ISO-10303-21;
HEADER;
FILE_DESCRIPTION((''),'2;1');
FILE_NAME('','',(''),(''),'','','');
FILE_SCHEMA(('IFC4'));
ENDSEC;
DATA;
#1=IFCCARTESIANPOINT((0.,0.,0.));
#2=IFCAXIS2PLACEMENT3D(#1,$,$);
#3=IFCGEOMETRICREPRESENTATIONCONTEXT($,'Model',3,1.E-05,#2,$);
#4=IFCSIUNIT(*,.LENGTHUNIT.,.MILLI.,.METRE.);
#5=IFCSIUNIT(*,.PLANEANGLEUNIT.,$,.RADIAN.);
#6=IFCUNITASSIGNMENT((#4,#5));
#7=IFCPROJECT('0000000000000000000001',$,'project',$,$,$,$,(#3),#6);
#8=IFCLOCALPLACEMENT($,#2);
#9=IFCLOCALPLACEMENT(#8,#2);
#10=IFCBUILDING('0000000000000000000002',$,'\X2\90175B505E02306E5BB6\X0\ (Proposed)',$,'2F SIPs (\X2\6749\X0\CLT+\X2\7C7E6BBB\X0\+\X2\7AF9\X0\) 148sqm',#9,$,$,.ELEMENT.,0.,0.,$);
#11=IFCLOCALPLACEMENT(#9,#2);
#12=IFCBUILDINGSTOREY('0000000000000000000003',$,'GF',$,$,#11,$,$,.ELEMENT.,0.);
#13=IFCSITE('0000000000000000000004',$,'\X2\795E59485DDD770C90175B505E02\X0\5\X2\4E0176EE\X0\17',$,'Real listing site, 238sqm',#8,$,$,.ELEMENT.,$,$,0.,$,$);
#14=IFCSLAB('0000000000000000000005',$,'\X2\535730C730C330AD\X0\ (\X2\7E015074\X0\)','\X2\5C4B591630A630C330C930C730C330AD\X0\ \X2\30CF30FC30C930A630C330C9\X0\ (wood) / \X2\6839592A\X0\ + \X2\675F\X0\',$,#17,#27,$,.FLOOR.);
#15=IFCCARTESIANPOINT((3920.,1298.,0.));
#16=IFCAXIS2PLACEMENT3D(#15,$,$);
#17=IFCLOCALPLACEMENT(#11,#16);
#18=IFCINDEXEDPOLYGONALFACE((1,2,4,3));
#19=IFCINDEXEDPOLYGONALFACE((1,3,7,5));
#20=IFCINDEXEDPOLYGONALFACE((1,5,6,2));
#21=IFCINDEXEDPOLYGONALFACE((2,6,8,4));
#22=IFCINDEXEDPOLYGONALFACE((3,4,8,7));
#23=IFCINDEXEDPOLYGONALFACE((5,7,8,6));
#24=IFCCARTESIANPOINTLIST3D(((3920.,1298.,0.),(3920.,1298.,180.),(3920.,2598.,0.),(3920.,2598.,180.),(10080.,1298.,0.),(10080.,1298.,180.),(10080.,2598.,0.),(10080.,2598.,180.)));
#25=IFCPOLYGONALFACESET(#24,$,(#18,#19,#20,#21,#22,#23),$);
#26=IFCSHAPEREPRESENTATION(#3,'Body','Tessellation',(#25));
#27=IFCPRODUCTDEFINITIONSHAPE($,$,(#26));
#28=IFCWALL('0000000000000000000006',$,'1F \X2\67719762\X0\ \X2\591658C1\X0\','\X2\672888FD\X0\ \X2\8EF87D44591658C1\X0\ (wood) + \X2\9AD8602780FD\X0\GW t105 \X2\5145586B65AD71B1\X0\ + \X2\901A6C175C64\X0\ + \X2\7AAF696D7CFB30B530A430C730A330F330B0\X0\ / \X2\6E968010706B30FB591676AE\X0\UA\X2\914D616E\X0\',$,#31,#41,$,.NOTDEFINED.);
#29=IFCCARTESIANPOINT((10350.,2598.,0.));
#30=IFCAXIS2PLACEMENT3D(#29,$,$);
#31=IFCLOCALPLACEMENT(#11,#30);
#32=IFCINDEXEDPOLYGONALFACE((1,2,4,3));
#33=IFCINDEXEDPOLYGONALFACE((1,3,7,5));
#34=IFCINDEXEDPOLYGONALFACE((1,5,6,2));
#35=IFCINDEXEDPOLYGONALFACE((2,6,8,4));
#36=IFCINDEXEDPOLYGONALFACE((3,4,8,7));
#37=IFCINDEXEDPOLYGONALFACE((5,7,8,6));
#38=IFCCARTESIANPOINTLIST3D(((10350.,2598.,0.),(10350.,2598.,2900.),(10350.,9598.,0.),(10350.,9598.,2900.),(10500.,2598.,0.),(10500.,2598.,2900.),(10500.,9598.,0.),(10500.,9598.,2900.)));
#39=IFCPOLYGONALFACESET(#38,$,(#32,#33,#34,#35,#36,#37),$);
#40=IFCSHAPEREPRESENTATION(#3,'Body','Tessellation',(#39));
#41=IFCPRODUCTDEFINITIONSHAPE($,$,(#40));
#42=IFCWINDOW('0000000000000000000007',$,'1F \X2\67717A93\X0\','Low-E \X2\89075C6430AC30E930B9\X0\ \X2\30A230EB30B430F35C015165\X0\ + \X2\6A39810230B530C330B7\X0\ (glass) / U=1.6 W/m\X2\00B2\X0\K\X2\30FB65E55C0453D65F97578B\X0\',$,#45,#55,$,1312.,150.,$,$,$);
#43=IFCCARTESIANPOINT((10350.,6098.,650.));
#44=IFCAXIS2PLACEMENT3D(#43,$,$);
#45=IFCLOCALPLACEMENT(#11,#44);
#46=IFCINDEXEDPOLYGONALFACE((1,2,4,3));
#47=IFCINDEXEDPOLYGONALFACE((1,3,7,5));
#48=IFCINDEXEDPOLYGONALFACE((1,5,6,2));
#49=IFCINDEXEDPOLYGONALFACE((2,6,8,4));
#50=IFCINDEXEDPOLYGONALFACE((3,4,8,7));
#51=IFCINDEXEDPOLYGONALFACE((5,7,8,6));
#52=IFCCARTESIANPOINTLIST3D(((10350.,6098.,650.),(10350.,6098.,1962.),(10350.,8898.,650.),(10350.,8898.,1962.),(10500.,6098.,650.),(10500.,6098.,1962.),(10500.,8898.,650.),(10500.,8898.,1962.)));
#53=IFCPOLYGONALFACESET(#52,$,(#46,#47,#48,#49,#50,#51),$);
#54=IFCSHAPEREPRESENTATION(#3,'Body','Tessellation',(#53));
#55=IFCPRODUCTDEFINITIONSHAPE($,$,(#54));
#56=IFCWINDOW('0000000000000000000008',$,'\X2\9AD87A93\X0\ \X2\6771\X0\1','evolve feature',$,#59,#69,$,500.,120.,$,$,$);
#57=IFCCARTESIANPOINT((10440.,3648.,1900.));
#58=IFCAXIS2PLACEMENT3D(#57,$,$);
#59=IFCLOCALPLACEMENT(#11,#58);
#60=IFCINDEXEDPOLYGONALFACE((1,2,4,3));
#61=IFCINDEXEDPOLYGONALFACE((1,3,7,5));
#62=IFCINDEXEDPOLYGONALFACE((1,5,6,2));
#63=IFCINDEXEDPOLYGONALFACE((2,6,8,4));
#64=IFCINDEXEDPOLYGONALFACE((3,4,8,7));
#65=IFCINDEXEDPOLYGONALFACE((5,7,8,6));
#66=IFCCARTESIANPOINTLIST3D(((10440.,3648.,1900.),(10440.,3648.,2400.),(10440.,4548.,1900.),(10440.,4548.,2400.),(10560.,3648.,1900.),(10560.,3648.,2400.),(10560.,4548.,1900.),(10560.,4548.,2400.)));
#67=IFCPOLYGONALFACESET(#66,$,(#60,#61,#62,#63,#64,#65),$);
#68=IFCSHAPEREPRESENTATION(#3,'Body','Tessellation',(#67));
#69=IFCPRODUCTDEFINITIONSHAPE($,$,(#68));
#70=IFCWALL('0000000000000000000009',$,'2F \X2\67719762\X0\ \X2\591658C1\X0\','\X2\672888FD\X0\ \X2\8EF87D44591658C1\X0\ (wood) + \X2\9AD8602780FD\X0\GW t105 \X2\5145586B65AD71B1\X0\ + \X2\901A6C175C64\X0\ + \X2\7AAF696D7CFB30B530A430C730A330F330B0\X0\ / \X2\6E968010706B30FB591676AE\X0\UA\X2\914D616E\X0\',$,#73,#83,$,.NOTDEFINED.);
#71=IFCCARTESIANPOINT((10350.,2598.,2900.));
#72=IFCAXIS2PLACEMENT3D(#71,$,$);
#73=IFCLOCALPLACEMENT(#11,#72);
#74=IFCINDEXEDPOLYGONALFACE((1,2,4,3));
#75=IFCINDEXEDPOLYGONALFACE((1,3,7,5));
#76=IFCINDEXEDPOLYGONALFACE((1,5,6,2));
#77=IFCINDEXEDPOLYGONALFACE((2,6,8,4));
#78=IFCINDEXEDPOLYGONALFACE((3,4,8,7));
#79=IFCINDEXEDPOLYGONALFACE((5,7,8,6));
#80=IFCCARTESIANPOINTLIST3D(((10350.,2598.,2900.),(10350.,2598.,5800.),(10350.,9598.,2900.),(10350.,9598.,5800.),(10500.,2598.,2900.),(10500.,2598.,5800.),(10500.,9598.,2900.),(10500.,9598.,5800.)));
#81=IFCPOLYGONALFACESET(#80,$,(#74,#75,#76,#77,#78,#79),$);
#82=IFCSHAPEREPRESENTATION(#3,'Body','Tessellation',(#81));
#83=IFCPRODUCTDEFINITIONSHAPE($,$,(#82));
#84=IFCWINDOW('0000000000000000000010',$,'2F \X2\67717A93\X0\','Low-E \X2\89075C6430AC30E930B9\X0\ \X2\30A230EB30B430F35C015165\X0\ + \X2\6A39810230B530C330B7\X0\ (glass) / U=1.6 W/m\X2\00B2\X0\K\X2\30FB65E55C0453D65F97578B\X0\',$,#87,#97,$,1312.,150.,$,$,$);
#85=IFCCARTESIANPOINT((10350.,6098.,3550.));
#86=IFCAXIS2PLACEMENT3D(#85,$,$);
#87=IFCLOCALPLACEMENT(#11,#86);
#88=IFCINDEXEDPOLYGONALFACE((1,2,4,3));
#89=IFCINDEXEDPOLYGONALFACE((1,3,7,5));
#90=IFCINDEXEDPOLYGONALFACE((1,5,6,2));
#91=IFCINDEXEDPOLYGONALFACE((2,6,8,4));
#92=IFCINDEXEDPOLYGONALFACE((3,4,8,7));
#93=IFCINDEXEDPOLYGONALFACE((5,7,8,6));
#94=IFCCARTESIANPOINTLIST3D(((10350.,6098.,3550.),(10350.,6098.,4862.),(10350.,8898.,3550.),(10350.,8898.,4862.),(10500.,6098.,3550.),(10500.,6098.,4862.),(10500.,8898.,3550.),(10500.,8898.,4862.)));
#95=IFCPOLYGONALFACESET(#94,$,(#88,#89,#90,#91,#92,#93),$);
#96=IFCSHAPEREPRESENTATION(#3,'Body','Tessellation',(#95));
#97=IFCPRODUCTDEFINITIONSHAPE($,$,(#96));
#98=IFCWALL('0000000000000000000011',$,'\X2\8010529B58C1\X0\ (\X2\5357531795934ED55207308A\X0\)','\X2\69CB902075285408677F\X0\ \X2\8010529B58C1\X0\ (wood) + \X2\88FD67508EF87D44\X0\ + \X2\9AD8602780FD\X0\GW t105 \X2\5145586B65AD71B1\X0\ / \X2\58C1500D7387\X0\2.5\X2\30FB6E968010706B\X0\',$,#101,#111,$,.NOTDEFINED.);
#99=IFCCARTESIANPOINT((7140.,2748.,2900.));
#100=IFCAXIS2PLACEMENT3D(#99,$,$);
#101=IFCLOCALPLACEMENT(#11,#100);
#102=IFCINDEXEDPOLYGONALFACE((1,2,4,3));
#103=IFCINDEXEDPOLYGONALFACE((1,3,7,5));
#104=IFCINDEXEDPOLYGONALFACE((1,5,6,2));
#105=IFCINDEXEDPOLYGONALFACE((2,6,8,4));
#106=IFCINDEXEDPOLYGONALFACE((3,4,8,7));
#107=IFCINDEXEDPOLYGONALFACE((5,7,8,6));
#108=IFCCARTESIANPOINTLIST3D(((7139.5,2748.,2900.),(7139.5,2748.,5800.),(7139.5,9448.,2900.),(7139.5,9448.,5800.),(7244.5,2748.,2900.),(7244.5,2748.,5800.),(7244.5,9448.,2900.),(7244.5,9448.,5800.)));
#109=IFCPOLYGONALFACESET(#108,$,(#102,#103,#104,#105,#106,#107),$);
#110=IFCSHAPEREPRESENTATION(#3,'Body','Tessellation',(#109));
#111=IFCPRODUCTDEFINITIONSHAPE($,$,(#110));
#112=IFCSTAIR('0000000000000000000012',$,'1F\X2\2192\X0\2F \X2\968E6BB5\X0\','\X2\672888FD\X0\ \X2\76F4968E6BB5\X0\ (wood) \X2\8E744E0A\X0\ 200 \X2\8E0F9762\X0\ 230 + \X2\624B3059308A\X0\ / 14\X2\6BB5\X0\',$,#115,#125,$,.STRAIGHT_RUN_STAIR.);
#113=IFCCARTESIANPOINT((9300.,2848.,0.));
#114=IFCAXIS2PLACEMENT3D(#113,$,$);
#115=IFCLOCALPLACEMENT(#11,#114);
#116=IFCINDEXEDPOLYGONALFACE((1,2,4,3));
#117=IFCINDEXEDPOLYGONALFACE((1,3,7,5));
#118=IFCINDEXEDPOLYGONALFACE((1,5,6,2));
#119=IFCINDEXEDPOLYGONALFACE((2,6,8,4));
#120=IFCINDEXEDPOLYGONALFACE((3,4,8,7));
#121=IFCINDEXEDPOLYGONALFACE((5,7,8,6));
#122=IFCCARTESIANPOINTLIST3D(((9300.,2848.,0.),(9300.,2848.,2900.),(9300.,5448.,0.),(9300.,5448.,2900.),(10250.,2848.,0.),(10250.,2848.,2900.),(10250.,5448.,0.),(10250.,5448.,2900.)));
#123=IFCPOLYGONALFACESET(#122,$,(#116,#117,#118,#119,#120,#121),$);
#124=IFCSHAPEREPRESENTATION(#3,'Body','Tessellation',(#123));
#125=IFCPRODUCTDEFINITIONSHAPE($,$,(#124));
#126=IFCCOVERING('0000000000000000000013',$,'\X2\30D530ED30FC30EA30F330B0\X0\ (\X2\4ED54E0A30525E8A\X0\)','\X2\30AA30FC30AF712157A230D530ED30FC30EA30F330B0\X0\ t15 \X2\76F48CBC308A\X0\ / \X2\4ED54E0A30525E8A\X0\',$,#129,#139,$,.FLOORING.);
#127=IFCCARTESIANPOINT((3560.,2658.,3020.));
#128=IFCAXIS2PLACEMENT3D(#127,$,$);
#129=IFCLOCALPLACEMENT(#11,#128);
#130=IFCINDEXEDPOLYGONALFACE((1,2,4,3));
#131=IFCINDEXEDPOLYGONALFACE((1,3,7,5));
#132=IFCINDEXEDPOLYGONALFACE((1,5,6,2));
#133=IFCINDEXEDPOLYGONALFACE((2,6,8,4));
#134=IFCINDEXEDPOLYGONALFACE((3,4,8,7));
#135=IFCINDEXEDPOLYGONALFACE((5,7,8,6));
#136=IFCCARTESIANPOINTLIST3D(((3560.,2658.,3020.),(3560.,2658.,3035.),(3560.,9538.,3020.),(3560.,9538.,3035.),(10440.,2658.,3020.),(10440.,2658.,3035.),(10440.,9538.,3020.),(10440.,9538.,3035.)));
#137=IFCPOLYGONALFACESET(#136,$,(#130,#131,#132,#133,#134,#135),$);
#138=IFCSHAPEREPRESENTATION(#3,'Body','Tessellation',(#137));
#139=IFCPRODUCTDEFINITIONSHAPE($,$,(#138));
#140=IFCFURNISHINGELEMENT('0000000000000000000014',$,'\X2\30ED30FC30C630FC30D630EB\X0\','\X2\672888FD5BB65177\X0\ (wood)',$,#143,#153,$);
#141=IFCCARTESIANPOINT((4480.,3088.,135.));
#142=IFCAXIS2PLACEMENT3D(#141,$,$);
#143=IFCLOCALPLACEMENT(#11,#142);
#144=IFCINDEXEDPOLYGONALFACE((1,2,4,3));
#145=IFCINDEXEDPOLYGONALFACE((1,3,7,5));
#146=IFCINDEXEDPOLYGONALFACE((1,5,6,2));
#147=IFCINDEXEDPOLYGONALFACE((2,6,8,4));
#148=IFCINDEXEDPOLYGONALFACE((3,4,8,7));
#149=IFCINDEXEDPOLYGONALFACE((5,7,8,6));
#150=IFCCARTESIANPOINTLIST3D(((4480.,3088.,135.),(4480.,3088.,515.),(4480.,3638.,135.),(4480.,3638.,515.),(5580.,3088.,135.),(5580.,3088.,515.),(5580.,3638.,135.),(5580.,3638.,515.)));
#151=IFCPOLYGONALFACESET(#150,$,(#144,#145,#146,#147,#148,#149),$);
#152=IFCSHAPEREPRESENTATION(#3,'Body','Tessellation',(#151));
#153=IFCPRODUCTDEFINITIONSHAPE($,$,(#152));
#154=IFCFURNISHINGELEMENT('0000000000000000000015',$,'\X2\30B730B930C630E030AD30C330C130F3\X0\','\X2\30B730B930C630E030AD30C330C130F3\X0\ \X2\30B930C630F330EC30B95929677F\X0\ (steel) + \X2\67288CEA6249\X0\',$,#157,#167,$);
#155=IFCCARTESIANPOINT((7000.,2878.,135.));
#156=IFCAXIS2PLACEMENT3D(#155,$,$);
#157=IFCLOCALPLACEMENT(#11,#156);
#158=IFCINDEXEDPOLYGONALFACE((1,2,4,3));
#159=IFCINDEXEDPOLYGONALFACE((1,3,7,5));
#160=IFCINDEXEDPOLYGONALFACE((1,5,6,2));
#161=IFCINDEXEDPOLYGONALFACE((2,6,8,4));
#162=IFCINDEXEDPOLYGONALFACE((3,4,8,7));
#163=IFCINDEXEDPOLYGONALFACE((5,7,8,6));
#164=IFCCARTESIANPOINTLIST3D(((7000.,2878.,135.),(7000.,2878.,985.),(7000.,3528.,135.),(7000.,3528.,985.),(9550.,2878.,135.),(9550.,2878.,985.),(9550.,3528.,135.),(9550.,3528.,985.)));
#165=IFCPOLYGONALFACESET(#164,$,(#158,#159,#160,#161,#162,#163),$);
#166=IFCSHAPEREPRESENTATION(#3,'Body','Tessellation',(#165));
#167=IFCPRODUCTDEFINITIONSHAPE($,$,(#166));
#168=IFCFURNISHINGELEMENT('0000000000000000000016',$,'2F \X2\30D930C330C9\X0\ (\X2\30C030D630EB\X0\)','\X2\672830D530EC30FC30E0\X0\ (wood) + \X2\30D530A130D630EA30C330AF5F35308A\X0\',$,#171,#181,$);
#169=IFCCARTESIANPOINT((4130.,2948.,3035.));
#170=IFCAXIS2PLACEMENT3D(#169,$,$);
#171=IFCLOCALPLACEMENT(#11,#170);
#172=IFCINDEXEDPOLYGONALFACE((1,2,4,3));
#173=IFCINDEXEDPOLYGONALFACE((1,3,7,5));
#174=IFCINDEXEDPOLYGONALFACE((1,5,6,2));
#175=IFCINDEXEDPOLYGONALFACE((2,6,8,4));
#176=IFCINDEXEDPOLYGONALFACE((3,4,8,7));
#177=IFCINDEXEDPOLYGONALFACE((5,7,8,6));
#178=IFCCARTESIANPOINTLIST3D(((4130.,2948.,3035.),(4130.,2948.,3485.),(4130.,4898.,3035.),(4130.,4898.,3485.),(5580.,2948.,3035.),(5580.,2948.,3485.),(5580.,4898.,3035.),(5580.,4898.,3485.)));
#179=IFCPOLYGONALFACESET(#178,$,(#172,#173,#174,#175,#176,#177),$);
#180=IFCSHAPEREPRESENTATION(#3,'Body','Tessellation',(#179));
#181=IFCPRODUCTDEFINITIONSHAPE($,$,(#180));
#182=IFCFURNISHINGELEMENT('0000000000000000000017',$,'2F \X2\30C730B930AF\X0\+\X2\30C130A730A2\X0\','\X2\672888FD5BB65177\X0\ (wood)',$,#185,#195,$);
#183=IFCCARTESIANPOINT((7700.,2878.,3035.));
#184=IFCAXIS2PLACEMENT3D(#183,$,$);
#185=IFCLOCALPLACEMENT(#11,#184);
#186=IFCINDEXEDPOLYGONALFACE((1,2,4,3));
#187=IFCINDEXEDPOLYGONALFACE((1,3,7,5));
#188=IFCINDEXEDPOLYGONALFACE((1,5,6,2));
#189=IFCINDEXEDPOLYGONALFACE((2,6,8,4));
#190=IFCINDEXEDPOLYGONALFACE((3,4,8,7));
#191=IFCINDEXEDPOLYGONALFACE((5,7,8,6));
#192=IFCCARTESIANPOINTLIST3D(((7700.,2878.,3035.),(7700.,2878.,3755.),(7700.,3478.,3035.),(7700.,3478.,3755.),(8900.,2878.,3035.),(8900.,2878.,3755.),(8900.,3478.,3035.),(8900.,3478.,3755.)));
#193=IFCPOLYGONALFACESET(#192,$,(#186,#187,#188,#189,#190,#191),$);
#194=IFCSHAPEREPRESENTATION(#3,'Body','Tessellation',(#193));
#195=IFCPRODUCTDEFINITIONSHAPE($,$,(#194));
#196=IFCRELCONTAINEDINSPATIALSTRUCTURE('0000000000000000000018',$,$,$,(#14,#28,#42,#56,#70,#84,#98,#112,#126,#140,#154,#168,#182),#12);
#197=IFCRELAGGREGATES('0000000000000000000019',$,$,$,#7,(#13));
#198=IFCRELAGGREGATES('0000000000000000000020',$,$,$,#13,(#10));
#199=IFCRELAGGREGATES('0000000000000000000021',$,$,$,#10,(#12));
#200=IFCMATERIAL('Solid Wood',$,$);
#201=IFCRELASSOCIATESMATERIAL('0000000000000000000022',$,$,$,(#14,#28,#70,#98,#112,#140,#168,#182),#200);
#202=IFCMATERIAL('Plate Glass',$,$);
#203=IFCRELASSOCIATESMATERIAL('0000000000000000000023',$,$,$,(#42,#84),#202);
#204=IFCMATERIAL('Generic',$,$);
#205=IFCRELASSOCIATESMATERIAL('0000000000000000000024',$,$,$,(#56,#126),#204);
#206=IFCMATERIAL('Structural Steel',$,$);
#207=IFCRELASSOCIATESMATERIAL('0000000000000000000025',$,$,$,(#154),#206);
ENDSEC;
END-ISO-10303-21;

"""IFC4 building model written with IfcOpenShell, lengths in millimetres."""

from ifc_helpers import new_model, si_unit, frame, frame_2d, origin, place, context, project, spatial, rectangle, extrude, material, element, fill, save


model = new_model("IFC4")

# Units and contexts
model_context = context("Model", 3, precision=1e-05, world=origin())
ifc_project = project(units=[si_unit("LENGTHUNIT", "METRE", prefix="MILLI"), si_unit("PLANEANGLEUNIT", "RADIAN")], contexts=[model_context])

# Site, building, storey
site_placement = place(None, origin())
site = spatial("IfcSite", under=ifc_project, at=site_placement, Name="神奈川県逗子市5丁目17", ObjectType="Real listing site, 238sqm", CompositionType="ELEMENT", RefElevation=0.0)
building_placement = place(site_placement, origin())
building = spatial("IfcBuilding", under=site, at=building_placement, Name="逗子市の家 (Proposed)", ObjectType="2F SIPs (杉CLT+籾殻+竹) 148sqm", CompositionType="ELEMENT", ElevationOfRefHeight=0.0, ElevationOfTerrain=0.0)
storey_placement = place(building_placement, origin())
storey = spatial("IfcBuildingStorey", under=building, at=storey_placement, Name="GF", CompositionType="ELEMENT", Elevation=0.0)

# Slab
ifc_material_1 = material(Name="Solid Wood")
slab_placement = place(storey_placement, frame((3920.0, 1298.0, 0.0)))
element("IfcSlab", 1, at=slab_placement, inside=storey, material=ifc_material_1, Name="南デッキ (縁側)", Description="屋外ウッドデッキ ハードウッド (wood) / 根太 + 束", PredefinedType="FLOOR", context=model_context, shape_type="SweptSolid", body=[
    extrude(rectangle(XDim=6160.0, YDim=1300.0, at=frame_2d((3080.0, 650.0))), frame((3920.0, 1298.0, 0.0)), (0.0, 0.0, 1.0), 180.0),
])

# Wall, openings, windows
wall_1_placement = place(storey_placement, frame((10350.0, 2598.0, 0.0)))
wall_1 = element("IfcWall", 2, at=wall_1_placement, inside=storey, material=ifc_material_1, Name="1F 東面 外壁", Description="木製 軸組外壁 (wood) + 高性能GW t105 充填断熱 + 通気層 + 窯業系サイディング / 準耐火・外皮UA配慮", PredefinedType="NOTDEFINED", context=model_context, shape_type="SweptSolid", body=[
    extrude(rectangle(XDim=150.0, YDim=7000.0, at=frame_2d((75.0, 3500.0))), frame((10350.0, 2598.0, 0.0)), (0.0, 0.0, 1.0), 2900.0),
])
opening_1_placement = place(storey_placement, frame((10350.0, 6098.0, 650.0)))
opening_1 = element("IfcOpeningElement", 3, at=opening_1_placement, cuts=wall_1, PredefinedType="NOTDEFINED", context=model_context, shape_type="SweptSolid", body=[
    extrude(rectangle(XDim=150.0, YDim=2800.0, at=frame_2d((75.0, 1400.0))), frame((10350.0, 6098.0, 650.0)), (0.0, 0.0, 1.0), 1312.0),
])
opening_2_placement = place(storey_placement, frame((10440.0, 3648.0, 1900.0)))
opening_2 = element("IfcOpeningElement", 4, at=opening_2_placement, cuts=wall_1, PredefinedType="NOTDEFINED", context=model_context, shape_type="SweptSolid", body=[
    extrude(rectangle(XDim=120.0, YDim=900.0, at=frame_2d((60.0, 450.0))), frame((10440.0, 3648.0, 1900.0)), (0.0, 0.0, 1.0), 500.0),
])
ifc_material_2 = material(Name="Plate Glass")
window_1_placement = place(storey_placement, frame((10350.0, 6098.0, 650.0)))
window_1 = element("IfcWindow", 5, at=window_1_placement, inside=storey, material=ifc_material_2, Name="1F 東窓", Description="Low-E 複層ガラス アルゴン封入 + 樹脂サッシ (glass) / U=1.6 W/m²K・日射取得型", OverallHeight=1312.0, OverallWidth=150.0, context=model_context, shape_type="SweptSolid", body=[
    extrude(rectangle(XDim=150.0, YDim=2800.0, at=frame_2d((75.0, 1400.0))), frame((10350.0, 6098.0, 650.0)), (0.0, 0.0, 1.0), 1312.0),
])
fill(opening_1, window_1)
ifc_material_3 = material(Name="Generic")
window_2_placement = place(storey_placement, frame((10440.0, 3648.0, 1900.0)))
window_2 = element("IfcWindow", 6, at=window_2_placement, inside=storey, material=ifc_material_3, Name="高窓 東1", Description="evolve feature", OverallHeight=500.0, OverallWidth=120.0, context=model_context, shape_type="SweptSolid", body=[
    extrude(rectangle(XDim=120.0, YDim=900.0, at=frame_2d((60.0, 450.0))), frame((10440.0, 3648.0, 1900.0)), (0.0, 0.0, 1.0), 500.0),
])
fill(opening_2, window_2)

# Wall, opening, window
wall_2_placement = place(storey_placement, frame((10350.0, 2598.0, 2900.0)))
wall_2 = element("IfcWall", 7, at=wall_2_placement, inside=storey, material=ifc_material_1, Name="2F 東面 外壁", Description="木製 軸組外壁 (wood) + 高性能GW t105 充填断熱 + 通気層 + 窯業系サイディング / 準耐火・外皮UA配慮", PredefinedType="NOTDEFINED", context=model_context, shape_type="SweptSolid", body=[
    extrude(rectangle(XDim=150.0, YDim=7000.0, at=frame_2d((75.0, 3500.0))), frame((10350.0, 2598.0, 2900.0)), (0.0, 0.0, 1.0), 2900.0),
])
opening_3_placement = place(storey_placement, frame((10350.0, 6098.0, 3550.0)))
opening_3 = element("IfcOpeningElement", 8, at=opening_3_placement, cuts=wall_2, PredefinedType="NOTDEFINED", context=model_context, shape_type="SweptSolid", body=[
    extrude(rectangle(XDim=150.0, YDim=2800.0, at=frame_2d((75.0, 1400.0))), frame((10350.0, 6098.0, 3550.0)), (0.0, 0.0, 1.0), 1312.0),
])
window_3_placement = place(storey_placement, frame((10350.0, 6098.0, 3550.0)))
window_3 = element("IfcWindow", 9, at=window_3_placement, inside=storey, material=ifc_material_2, Name="2F 東窓", Description="Low-E 複層ガラス アルゴン封入 + 樹脂サッシ (glass) / U=1.6 W/m²K・日射取得型", OverallHeight=1312.0, OverallWidth=150.0, context=model_context, shape_type="SweptSolid", body=[
    extrude(rectangle(XDim=150.0, YDim=2800.0, at=frame_2d((75.0, 1400.0))), frame((10350.0, 6098.0, 3550.0)), (0.0, 0.0, 1.0), 1312.0),
])
fill(opening_3, window_3)

# Wall
wall_3_placement = place(storey_placement, frame((7140.0, 2748.0, 2900.0)))
element("IfcWall", 10, at=wall_3_placement, inside=storey, material=ifc_material_1, Name="耐力壁 (南北間仕切り)", Description="構造用合板 耐力壁 (wood) + 製材軸組 + 高性能GW t105 充填断熱 / 壁倍率2.5・準耐火", PredefinedType="NOTDEFINED", context=model_context, shape_type="SweptSolid", body=[
    extrude(rectangle(XDim=105.0, YDim=6700.0, at=frame_2d((52.0, 3350.0))), frame((7140.0, 2748.0, 2900.0)), (0.0, 0.0, 1.0), 2900.0),
])

# Stair
stair_placement = place(storey_placement, frame((9300.0, 2848.0, 0.0)))
element("IfcStair", 11, at=stair_placement, inside=storey, material=ifc_material_1, Name="1F→2F 階段", Description="木製 直階段 (wood) 蹴上 200 踏面 230 + 手すり / 14段", PredefinedType="STRAIGHT_RUN_STAIR", context=model_context, shape_type="SweptSolid", body=[
    extrude(rectangle(XDim=950.0, YDim=2600.0, at=frame_2d((475.0, 1300.0))), frame((9300.0, 2848.0, 0.0)), (0.0, 0.0, 1.0), 2900.0),
])

# Covering
covering_placement = place(storey_placement, frame((3560.0, 2658.0, 3020.0)))
element("IfcCovering", 12, at=covering_placement, inside=storey, material=ifc_material_3, Name="フローリング (仕上げ床)", Description="オーク無垢フローリング t15 直貼り / 仕上げ床", PredefinedType="FLOORING", context=model_context, shape_type="SweptSolid", body=[
    extrude(rectangle(XDim=6880.0, YDim=6880.0, at=frame_2d((3440.0, 3440.0))), frame((3560.0, 2658.0, 3020.0)), (0.0, 0.0, 1.0), 15.0),
])

# Furnishing elements
furnishing_1_placement = place(storey_placement, frame((4480.0, 3088.0, 135.0)))
element("IfcFurnishingElement", 13, at=furnishing_1_placement, inside=storey, material=ifc_material_1, Name="ローテーブル", Description="木製家具 (wood)", context=model_context, shape_type="SweptSolid", body=[
    extrude(rectangle(XDim=1100.0, YDim=550.0, at=frame_2d((550.0, 275.0))), frame((4480.0, 3088.0, 135.0)), (0.0, 0.0, 1.0), 380.0),
])
ifc_material_4 = material(Name="Structural Steel")
furnishing_2_placement = place(storey_placement, frame((7000.0, 2878.0, 135.0)))
element("IfcFurnishingElement", 14, at=furnishing_2_placement, inside=storey, material=ifc_material_4, Name="システムキッチン", Description="システムキッチン ステンレス天板 (steel) + 木質扉", context=model_context, shape_type="SweptSolid", body=[
    extrude(rectangle(XDim=2550.0, YDim=650.0, at=frame_2d((1275.0, 325.0))), frame((7000.0, 2878.0, 135.0)), (0.0, 0.0, 1.0), 850.0),
])
furnishing_3_placement = place(storey_placement, frame((4130.0, 2948.0, 3035.0)))
element("IfcFurnishingElement", 15, at=furnishing_3_placement, inside=storey, material=ifc_material_1, Name="2F ベッド (ダブル)", Description="木フレーム (wood) + ファブリック張り", context=model_context, shape_type="SweptSolid", body=[
    extrude(rectangle(XDim=1450.0, YDim=1950.0, at=frame_2d((725.0, 975.0))), frame((4130.0, 2948.0, 3035.0)), (0.0, 0.0, 1.0), 450.0),
])
furnishing_4_placement = place(storey_placement, frame((7700.0, 2878.0, 3035.0)))
element("IfcFurnishingElement", 16, at=furnishing_4_placement, inside=storey, material=ifc_material_1, Name="2F デスク+チェア", Description="木製家具 (wood)", context=model_context, shape_type="SweptSolid", body=[
    extrude(rectangle(XDim=1200.0, YDim=600.0, at=frame_2d((600.0, 300.0))), frame((7700.0, 2878.0, 3035.0)), (0.0, 0.0, 1.0), 720.0),
])

save(model, "model.ifc")
